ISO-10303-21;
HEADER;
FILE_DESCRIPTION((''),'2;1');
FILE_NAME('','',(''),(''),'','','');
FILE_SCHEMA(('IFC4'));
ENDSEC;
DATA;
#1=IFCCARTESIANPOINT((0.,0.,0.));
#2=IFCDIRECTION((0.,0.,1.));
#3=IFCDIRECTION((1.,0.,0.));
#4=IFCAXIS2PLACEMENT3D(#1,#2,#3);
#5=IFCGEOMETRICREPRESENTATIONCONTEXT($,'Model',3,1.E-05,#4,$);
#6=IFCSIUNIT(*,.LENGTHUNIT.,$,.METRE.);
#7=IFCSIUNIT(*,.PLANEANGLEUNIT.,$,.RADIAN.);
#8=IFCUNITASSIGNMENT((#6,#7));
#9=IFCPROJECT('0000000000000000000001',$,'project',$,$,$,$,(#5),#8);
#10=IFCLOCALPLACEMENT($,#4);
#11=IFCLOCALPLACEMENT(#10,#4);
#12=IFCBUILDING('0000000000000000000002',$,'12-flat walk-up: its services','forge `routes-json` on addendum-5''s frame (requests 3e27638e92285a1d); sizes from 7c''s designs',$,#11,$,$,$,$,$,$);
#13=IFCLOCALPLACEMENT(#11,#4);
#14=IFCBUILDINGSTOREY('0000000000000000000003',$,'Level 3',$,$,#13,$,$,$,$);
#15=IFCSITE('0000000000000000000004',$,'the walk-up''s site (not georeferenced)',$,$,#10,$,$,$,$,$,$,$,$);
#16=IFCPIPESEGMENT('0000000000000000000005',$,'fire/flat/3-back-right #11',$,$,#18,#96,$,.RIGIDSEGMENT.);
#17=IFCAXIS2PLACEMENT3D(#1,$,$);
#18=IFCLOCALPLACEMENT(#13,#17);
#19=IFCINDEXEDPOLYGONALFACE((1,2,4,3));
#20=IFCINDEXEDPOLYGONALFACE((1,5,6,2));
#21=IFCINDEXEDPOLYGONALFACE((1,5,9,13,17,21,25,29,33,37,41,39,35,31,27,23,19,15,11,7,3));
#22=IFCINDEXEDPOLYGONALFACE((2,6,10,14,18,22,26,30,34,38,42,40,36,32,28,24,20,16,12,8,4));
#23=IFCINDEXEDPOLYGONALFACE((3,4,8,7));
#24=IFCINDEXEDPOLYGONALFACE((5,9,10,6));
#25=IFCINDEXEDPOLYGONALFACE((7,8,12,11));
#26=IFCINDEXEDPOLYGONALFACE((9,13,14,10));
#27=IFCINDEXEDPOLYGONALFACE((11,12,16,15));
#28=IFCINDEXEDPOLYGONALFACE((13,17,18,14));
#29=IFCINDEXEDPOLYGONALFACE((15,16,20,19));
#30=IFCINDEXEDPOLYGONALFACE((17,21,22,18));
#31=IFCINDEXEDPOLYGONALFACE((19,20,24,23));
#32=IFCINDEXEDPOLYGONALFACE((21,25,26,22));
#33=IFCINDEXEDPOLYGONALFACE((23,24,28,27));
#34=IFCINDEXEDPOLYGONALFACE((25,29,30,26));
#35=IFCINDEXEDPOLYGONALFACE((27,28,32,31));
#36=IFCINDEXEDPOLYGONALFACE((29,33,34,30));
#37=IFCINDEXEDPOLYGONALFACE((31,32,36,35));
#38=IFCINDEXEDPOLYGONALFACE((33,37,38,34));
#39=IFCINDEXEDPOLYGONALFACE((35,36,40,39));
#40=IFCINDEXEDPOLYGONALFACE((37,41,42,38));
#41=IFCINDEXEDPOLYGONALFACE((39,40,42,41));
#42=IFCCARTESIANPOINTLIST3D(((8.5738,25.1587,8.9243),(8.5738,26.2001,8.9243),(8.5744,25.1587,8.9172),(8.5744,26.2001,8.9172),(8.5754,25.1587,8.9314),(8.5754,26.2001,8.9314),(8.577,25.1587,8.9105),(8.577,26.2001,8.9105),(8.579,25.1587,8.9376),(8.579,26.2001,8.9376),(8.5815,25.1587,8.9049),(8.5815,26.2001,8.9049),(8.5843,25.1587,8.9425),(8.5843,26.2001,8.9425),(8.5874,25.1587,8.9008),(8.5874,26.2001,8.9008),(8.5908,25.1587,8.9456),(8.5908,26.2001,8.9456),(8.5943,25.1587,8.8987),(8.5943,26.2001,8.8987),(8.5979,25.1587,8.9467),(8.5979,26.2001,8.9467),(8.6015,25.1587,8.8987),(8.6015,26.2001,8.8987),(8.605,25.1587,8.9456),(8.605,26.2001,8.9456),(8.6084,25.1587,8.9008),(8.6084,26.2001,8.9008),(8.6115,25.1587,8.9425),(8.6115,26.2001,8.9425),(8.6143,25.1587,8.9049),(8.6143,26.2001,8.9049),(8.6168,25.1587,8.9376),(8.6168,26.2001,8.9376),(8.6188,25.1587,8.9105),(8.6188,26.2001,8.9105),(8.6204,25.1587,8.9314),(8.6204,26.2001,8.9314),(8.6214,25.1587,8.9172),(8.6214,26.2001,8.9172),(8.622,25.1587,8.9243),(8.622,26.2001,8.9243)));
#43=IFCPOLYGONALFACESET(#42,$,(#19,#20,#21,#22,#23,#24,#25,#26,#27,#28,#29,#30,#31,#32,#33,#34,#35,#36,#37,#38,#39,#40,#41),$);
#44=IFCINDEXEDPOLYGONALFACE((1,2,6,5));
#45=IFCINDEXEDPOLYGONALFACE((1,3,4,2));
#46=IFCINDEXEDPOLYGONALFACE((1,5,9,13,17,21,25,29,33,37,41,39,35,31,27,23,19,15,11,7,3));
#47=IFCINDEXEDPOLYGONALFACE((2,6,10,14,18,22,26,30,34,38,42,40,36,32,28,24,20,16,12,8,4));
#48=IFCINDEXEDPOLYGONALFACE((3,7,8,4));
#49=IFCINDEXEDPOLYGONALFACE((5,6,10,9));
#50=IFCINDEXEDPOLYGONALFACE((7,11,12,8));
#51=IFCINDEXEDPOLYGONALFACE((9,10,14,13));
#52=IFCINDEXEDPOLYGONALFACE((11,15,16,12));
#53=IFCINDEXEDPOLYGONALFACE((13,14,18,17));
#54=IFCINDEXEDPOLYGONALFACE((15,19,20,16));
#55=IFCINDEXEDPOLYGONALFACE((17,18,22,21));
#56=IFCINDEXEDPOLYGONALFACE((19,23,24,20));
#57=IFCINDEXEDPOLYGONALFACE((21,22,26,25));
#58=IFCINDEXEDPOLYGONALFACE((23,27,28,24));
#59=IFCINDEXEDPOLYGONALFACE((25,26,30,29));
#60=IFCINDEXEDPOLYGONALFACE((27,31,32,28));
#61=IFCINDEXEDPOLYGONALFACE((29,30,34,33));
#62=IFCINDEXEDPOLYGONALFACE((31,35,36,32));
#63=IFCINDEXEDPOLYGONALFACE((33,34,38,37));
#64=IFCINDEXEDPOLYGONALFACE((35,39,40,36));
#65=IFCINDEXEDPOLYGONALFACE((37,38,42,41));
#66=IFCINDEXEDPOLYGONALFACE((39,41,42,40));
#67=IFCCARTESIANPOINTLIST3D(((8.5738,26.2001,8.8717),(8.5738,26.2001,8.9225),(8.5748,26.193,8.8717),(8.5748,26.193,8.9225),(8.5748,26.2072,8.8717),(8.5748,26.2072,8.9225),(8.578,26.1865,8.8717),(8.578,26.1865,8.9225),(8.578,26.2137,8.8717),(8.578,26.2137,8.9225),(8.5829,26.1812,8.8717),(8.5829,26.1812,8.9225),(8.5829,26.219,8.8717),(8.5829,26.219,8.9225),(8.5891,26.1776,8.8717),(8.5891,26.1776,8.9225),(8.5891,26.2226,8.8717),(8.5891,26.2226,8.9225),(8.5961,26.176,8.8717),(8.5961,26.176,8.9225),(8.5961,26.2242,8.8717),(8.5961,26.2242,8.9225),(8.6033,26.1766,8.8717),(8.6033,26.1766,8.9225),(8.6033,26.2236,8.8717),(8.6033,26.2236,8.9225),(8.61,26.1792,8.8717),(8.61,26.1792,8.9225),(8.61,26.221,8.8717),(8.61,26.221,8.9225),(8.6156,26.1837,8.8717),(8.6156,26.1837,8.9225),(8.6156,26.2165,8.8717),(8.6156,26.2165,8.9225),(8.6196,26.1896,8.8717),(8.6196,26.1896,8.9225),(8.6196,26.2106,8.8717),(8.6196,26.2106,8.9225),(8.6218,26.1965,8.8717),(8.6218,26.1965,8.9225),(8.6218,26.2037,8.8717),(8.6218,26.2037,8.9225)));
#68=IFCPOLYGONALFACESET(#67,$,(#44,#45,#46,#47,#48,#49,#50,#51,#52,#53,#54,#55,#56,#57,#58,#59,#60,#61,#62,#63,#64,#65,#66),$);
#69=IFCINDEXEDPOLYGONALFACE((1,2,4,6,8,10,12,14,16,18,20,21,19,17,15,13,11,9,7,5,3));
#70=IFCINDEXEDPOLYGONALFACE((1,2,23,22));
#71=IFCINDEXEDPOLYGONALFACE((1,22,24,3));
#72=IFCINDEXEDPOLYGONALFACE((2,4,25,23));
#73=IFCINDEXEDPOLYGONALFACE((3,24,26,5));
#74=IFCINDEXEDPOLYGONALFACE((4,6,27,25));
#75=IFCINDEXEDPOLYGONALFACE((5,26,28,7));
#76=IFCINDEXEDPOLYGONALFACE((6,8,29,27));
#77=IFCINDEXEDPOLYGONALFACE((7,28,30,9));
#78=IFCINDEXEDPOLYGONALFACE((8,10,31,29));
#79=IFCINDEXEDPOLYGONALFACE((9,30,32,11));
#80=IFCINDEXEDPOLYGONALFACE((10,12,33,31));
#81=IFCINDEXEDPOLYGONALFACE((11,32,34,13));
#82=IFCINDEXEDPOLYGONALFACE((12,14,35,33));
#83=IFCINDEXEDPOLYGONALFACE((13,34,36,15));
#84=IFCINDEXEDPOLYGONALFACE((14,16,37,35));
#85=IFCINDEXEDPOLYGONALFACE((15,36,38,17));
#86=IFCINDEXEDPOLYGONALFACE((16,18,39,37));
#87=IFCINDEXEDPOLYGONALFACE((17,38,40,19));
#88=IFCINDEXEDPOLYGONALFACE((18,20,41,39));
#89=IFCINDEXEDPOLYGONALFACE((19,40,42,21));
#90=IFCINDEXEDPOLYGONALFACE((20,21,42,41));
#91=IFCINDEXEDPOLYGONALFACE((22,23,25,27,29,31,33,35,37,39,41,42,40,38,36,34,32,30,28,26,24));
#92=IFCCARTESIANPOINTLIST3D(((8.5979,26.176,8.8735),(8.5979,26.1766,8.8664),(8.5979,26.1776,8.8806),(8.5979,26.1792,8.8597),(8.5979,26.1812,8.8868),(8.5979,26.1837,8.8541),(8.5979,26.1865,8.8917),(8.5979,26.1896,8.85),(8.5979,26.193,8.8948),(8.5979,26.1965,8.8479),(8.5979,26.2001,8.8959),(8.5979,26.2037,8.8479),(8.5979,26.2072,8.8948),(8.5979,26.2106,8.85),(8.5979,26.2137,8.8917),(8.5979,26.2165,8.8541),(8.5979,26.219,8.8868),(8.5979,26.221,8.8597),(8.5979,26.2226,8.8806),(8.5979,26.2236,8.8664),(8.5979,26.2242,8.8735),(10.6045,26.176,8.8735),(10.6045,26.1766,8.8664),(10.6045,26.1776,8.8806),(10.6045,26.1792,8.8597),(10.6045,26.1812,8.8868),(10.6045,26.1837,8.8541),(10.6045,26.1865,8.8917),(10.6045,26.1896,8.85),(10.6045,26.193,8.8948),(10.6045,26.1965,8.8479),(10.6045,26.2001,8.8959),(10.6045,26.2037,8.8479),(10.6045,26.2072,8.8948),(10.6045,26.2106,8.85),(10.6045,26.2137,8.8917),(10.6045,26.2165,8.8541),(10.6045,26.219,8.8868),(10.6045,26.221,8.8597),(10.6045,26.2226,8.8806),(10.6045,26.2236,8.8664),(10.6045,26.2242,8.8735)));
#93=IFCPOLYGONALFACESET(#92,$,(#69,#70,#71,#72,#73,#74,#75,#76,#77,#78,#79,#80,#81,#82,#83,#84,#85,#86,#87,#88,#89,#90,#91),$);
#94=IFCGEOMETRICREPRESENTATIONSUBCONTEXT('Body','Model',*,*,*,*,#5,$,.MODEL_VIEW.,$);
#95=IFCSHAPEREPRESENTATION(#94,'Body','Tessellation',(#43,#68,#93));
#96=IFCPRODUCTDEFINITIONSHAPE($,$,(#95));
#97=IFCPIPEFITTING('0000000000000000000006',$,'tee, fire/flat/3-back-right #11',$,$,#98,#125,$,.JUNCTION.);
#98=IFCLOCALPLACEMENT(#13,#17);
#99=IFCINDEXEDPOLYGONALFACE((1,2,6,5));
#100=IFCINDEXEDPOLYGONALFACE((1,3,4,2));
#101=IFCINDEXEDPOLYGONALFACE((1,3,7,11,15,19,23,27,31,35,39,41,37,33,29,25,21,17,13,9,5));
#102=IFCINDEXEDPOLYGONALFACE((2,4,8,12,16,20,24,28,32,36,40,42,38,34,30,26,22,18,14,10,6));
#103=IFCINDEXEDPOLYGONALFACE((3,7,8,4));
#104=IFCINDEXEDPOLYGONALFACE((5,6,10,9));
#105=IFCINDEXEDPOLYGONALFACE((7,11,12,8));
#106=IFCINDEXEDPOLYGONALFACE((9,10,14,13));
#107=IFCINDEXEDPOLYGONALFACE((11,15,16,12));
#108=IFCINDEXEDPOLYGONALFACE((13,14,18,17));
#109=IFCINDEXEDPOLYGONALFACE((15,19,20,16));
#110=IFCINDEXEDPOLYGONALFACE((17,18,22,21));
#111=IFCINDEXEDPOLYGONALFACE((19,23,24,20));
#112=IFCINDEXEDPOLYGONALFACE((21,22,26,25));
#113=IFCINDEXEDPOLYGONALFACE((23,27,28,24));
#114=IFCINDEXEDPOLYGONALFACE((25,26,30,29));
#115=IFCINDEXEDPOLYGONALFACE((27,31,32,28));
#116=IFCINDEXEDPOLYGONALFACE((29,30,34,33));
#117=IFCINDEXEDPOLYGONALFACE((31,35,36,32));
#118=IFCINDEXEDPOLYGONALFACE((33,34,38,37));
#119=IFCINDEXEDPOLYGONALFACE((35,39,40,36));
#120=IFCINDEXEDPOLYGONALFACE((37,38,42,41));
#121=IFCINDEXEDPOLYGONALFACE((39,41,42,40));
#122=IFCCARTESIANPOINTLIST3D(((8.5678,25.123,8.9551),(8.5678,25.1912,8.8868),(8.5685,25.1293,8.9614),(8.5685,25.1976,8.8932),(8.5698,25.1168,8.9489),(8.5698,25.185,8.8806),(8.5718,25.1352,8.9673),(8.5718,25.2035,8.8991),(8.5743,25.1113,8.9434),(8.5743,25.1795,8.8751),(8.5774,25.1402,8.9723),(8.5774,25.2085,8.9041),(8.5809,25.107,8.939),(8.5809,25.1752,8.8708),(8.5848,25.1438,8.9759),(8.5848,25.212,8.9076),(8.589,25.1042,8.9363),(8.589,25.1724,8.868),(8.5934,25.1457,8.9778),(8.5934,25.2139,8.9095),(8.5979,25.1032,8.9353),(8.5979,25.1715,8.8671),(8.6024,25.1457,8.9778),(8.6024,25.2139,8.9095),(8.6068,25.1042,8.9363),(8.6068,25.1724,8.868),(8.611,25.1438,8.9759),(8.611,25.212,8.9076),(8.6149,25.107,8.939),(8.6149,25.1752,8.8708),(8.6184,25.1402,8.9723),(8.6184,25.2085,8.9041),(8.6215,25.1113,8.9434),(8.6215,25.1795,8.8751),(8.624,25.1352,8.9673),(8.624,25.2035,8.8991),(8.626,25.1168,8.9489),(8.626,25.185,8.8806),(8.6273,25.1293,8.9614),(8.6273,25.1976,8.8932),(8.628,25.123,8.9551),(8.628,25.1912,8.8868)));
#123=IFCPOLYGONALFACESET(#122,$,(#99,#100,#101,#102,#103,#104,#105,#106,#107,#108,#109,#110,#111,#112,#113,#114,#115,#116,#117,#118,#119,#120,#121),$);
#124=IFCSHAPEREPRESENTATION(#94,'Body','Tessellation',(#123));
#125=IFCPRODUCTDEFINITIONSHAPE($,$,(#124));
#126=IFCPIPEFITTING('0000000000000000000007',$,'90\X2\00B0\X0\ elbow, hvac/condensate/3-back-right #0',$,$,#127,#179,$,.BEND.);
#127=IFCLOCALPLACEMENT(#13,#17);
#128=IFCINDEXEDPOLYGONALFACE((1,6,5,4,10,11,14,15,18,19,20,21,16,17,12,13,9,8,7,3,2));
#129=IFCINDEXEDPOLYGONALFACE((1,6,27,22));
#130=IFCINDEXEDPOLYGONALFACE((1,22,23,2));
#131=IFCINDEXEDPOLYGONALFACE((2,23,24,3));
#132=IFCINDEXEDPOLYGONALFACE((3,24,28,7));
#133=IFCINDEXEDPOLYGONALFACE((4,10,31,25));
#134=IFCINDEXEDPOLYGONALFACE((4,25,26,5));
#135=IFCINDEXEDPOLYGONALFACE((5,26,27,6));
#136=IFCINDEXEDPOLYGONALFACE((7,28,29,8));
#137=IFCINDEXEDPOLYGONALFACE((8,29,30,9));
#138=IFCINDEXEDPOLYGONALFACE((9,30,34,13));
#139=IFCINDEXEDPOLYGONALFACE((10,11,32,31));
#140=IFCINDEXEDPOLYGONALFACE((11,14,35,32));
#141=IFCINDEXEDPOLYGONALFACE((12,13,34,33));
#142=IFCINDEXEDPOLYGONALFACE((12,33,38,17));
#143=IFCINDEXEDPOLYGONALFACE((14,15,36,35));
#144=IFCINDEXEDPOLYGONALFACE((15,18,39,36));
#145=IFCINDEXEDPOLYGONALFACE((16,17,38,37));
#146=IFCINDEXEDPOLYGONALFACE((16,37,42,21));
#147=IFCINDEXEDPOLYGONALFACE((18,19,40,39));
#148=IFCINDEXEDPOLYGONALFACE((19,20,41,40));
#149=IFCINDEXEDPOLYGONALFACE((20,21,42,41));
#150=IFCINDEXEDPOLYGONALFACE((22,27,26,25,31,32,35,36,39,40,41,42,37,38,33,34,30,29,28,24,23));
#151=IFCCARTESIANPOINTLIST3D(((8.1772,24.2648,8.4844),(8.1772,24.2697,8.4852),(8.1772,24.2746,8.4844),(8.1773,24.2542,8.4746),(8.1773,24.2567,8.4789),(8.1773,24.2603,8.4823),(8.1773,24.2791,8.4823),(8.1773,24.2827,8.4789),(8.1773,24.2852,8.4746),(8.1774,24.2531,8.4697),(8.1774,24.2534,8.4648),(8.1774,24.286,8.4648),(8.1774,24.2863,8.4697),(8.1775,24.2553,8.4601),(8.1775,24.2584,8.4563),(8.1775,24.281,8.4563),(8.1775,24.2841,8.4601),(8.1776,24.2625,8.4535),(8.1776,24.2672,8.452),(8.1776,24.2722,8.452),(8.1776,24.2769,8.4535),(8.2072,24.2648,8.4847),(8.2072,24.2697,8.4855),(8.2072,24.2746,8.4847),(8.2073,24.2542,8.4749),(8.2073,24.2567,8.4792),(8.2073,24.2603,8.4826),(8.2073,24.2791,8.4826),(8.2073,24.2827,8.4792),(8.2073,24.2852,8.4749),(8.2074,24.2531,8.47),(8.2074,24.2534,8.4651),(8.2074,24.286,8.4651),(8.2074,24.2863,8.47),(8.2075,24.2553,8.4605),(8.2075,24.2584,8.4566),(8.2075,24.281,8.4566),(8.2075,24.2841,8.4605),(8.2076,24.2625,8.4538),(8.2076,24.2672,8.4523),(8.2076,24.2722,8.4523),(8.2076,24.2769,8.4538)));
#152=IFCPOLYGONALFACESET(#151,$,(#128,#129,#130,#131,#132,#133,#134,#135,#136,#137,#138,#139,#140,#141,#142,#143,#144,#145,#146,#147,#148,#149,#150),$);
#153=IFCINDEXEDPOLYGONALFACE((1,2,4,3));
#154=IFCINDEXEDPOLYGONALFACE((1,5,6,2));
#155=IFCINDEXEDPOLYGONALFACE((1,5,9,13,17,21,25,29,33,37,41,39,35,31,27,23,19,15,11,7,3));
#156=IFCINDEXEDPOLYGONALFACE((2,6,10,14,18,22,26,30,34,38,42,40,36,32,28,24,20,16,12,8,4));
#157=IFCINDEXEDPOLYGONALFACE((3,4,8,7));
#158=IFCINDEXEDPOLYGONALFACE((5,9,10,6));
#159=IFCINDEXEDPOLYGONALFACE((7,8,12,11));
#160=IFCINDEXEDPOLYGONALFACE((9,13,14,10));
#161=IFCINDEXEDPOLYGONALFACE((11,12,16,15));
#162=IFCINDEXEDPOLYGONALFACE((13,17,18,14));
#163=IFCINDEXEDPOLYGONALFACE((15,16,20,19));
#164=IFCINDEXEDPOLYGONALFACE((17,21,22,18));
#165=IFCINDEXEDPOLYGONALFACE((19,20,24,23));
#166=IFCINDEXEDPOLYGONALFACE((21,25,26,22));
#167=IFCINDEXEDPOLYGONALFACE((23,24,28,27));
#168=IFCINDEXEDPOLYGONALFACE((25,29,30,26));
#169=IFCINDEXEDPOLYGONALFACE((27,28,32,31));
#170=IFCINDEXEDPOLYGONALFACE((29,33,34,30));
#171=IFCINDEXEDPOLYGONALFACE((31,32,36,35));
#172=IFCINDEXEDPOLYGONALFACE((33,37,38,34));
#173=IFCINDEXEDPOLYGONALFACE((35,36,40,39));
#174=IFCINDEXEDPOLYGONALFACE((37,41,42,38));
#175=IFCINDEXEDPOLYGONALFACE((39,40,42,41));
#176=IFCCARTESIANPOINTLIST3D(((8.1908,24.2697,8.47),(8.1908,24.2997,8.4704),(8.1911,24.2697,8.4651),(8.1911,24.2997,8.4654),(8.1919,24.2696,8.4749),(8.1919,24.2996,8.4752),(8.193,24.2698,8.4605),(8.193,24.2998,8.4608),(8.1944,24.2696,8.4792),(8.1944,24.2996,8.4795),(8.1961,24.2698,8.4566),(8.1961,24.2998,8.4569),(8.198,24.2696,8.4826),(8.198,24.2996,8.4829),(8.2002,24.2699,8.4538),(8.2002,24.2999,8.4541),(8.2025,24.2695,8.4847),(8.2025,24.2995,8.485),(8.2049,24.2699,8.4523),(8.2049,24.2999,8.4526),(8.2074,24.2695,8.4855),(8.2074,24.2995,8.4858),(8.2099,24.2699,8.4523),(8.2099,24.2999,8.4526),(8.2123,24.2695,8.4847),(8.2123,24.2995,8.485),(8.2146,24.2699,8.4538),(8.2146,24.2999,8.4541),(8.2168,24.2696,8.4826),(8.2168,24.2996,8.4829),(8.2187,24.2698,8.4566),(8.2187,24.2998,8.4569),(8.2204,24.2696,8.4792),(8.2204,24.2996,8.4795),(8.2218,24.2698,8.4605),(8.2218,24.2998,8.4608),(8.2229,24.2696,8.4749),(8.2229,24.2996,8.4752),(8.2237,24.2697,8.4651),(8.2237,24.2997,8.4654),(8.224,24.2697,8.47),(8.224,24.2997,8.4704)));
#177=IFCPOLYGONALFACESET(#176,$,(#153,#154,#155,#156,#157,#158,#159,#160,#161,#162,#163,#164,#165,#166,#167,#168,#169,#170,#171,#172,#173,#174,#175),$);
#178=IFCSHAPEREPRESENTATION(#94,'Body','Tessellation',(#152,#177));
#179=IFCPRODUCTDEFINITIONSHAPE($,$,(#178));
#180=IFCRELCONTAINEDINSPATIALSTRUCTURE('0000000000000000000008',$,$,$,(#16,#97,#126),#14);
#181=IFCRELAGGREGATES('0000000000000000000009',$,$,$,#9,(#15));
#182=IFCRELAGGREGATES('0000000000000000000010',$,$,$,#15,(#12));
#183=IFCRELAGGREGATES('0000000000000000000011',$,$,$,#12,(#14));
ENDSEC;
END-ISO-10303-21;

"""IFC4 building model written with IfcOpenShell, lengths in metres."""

from ifc_helpers import new_model, entity, si_unit, frame, origin_with_axes, place, context, subcontext, project, spatial, element, save


model = new_model("IFC4")

# Units and contexts
model_context = context("Model", 3, precision=1e-05, world=origin_with_axes())
body_context = subcontext(model_context, "Body", "Model", "MODEL_VIEW")
ifc_project = project(units=[si_unit("LENGTHUNIT", "METRE"), si_unit("PLANEANGLEUNIT", "RADIAN")], contexts=[model_context])

# Site, building, storey
site_placement = place(None, origin_with_axes())
site = spatial("IfcSite", under=ifc_project, at=site_placement, Name="the walk-up's site (not georeferenced)")
building_placement = place(site_placement, origin_with_axes())
building = spatial("IfcBuilding", under=site, at=building_placement, Name="12-flat walk-up: its services", Description="forge `routes-json` on addendum-5's frame (requests 3e27638e92285a1d); sizes from 7c's designs")
storey_placement = place(building_placement, origin_with_axes())
storey = spatial("IfcBuildingStorey", under=building, at=storey_placement, Name="Level 3")

# Pipe segment
pipe_segment_1_placement = place(storey_placement, frame((8.5979, 25.1587, 8.9225), z_axis=(0.0, 0.0, 1.0), x_axis=(1.0, 0.0, 0.0)))
element("IfcPipeSegment", 1, at=pipe_segment_1_placement, inside=storey, Name="fire/flat/3-back-right #11", PredefinedType="RIGIDSEGMENT", context=body_context, shape_type="AdvancedSweptSolid", body=[
    entity("IfcSweptDiskSolid", entity("IfcPolyline", [entity("IfcCartesianPoint", [0.0, 0.0, 0.0]), entity("IfcCartesianPoint", [0.0, 1.0414, 0.0])]), 0.0241),
    entity("IfcSweptDiskSolid", entity("IfcPolyline", [entity("IfcCartesianPoint", [0.0, 1.0414, 0.0]), entity("IfcCartesianPoint", [0.0, 1.0414, -0.0508])]), 0.0241),
    entity("IfcSweptDiskSolid", entity("IfcPolyline", [entity("IfcCartesianPoint", [0.0, 1.0414, -0.0508]), entity("IfcCartesianPoint", [2.0066, 1.0414, -0.0508])]), 0.0241),
])

# Pipe fittings
pipe_fitting_1_placement = place(storey_placement, frame((8.5979, 25.1246, 8.9567), z_axis=(0.0, 0.0, 1.0), x_axis=(1.0, 0.0, 0.0)))
element("IfcPipeFitting", 2, at=pipe_fitting_1_placement, inside=storey, Name="tee, fire/flat/3-back-right #11", PredefinedType="JUNCTION", context=body_context, shape_type="AdvancedSweptSolid", body=[
    entity("IfcSweptDiskSolid", entity("IfcPolyline", [entity("IfcCartesianPoint", [0.0, 0.0, 0.0]), entity("IfcCartesianPoint", [0.0, 0.0682, -0.0682])]), 0.0302),
])
pipe_fitting_2_placement = place(storey_placement, frame((8.1774, 24.2697, 8.4685), z_axis=(0.0, 0.0, 1.0), x_axis=(1.0, 0.0, 0.0)))
element("IfcPipeFitting", 3, at=pipe_fitting_2_placement, inside=storey, Name="90° elbow, hvac/condensate/3-back-right #0", PredefinedType="BEND", context=body_context, shape_type="AdvancedSweptSolid", body=[
    entity("IfcSweptDiskSolid", entity("IfcPolyline", [entity("IfcCartesianPoint", [0.0, 0.0, 0.0]), entity("IfcCartesianPoint", [0.03, 0.0, 0.0003])]), 0.0167),
    entity("IfcSweptDiskSolid", entity("IfcPolyline", [entity("IfcCartesianPoint", [0.03, 0.0, 0.0003]), entity("IfcCartesianPoint", [0.03, 0.03, 0.0006])]), 0.0167),
])

save(model, "model.ifc")
